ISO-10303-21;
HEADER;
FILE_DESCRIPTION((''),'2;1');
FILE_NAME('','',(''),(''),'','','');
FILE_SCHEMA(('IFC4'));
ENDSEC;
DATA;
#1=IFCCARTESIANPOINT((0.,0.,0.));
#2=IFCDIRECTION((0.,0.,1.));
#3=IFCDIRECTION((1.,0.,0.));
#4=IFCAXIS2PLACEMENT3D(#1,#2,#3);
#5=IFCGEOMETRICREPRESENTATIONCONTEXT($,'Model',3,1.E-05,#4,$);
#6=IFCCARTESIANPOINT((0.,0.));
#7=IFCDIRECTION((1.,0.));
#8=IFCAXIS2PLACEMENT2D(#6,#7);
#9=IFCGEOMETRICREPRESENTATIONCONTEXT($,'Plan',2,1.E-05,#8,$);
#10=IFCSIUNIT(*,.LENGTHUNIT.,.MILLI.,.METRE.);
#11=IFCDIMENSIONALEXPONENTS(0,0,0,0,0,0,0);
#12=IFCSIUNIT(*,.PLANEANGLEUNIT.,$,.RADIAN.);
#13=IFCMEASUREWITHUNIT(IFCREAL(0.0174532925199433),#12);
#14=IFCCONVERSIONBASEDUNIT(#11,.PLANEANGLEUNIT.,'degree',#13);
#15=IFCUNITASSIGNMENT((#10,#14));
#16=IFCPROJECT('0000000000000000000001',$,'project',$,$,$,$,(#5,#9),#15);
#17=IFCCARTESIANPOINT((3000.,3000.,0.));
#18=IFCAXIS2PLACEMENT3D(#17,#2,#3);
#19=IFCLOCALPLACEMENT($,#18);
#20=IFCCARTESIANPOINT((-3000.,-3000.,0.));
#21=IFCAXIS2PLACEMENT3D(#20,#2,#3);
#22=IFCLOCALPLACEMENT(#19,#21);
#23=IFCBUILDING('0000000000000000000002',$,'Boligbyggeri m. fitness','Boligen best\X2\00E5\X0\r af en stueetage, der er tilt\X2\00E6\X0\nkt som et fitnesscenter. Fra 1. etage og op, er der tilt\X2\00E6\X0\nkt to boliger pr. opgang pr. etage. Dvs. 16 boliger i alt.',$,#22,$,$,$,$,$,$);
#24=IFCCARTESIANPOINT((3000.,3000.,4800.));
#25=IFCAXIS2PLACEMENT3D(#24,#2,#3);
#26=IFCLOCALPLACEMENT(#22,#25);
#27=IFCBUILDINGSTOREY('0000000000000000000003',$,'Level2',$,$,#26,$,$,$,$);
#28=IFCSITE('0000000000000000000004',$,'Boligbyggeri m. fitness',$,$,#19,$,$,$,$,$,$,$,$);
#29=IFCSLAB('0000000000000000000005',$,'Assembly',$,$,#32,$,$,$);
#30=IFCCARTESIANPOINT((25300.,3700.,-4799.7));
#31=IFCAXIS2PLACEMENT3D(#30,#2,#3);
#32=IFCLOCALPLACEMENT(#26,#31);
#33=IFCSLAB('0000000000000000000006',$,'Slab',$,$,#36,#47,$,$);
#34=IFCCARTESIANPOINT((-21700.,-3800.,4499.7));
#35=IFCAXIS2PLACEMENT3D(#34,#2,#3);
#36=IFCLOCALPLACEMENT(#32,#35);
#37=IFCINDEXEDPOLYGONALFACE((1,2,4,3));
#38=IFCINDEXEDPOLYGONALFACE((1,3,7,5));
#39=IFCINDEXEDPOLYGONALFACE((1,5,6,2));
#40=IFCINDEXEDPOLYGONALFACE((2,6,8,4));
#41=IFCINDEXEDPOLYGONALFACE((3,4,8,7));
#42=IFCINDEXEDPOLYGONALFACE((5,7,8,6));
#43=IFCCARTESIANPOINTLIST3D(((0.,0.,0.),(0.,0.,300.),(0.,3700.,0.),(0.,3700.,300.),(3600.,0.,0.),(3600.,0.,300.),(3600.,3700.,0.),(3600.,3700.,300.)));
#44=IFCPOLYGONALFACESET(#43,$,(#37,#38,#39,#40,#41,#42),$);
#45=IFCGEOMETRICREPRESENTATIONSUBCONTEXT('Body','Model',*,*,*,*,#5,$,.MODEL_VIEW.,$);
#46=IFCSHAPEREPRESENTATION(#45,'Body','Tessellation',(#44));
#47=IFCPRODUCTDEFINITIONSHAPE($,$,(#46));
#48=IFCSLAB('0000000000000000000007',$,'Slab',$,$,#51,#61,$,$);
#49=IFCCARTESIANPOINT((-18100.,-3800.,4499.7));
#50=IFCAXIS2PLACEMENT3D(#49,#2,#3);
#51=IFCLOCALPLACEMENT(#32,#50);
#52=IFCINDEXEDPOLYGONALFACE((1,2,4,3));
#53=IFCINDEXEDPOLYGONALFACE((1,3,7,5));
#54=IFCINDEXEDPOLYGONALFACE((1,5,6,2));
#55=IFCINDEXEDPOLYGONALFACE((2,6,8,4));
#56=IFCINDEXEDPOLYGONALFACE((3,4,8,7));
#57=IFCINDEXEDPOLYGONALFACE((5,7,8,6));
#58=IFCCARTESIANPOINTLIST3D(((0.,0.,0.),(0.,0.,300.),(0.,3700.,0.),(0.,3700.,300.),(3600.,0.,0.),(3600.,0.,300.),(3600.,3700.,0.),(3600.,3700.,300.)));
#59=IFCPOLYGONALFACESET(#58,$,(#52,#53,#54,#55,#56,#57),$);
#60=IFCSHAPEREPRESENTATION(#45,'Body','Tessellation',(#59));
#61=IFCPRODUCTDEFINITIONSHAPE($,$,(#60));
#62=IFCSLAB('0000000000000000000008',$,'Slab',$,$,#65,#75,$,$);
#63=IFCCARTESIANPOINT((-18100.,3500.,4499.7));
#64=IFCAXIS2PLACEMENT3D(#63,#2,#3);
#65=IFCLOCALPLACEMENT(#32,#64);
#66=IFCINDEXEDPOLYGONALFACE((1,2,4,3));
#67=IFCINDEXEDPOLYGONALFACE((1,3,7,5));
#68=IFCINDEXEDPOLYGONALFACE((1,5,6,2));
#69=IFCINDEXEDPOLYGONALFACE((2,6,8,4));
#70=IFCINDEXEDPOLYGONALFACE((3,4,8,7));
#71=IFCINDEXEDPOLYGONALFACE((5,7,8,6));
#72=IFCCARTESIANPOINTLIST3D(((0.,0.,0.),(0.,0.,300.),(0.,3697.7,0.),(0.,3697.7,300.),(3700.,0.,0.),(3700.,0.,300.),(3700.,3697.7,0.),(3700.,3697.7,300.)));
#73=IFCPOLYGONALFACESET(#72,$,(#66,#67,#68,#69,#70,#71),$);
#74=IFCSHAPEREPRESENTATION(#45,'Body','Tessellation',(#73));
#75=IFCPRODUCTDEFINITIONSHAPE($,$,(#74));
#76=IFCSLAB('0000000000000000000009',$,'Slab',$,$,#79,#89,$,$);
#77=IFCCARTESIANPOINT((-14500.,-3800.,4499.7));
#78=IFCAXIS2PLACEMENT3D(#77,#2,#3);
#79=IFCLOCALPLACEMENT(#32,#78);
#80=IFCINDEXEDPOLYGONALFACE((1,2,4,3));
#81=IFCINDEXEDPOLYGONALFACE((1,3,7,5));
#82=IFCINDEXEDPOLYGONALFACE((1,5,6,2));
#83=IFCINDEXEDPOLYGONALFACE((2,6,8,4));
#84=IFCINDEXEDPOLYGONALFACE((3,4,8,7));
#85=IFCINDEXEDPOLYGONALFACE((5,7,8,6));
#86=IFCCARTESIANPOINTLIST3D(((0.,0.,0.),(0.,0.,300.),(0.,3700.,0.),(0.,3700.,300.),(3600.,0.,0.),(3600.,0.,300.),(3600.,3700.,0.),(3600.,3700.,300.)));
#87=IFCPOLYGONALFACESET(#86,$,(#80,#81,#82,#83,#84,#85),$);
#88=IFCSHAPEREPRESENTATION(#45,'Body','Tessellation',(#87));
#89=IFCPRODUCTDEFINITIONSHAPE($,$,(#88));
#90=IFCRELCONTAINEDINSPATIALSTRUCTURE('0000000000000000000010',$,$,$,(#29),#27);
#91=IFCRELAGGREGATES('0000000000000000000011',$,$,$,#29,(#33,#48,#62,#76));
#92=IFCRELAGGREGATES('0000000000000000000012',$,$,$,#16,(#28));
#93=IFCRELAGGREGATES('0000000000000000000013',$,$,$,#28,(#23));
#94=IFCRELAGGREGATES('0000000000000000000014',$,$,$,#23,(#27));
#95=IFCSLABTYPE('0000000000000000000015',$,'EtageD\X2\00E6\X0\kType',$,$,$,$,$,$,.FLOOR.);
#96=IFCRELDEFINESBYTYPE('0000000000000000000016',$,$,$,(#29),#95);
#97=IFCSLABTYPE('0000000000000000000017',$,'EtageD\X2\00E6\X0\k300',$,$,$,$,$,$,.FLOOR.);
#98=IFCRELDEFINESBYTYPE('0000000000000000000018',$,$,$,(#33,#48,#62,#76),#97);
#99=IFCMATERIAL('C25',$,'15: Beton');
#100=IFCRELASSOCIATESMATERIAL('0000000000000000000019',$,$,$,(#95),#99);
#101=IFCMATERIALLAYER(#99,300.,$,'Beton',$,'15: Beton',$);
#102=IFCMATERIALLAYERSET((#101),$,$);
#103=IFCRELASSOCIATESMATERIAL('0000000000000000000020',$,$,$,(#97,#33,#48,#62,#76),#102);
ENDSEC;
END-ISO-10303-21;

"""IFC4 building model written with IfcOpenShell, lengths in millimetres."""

from ifc_helpers import new_model, entity, si_unit, converted_unit, frame, origin_with_axes, origin_2d_with_axis, place, context, subcontext, project, spatial, line, indexed_curve, outline, extrude, material, layer, layer_set, layer_usage, type_object, element, aggregate, save


model = new_model("IFC4")

# Units and contexts
model_context = context("Model", 3, precision=1e-05, world=origin_with_axes())
plan_context = context("Plan", 2, precision=1e-05, world=origin_2d_with_axis())
body_context = subcontext(model_context, "Body", "Model", "MODEL_VIEW")
ifc_project = project(units=[si_unit("LENGTHUNIT", "METRE", prefix="MILLI"), converted_unit("PLANEANGLEUNIT", "degree", entity("IfcReal", 0.0174532925199433), si_unit("PLANEANGLEUNIT", "RADIAN"), dimensions=[0, 0, 0, 0, 0, 0, 0])], contexts=[model_context, plan_context])

# Site, building, storey
site_placement = place(None, frame((3000.0, 3000.0, 0.0), z_axis=(0.0, 0.0, 1.0), x_axis=(1.0, 0.0, 0.0)))
site = spatial("IfcSite", under=ifc_project, at=site_placement, Name="Boligbyggeri m. fitness")
building_placement = place(site_placement, frame((-3000.0, -3000.0, 0.0), z_axis=(0.0, 0.0, 1.0), x_axis=(1.0, 0.0, 0.0)))
building = spatial("IfcBuilding", under=site, at=building_placement, Name="Boligbyggeri m. fitness", Description="Boligen består af en stueetage, der er tiltænkt som et fitnesscenter. Fra 1. etage og op, er der tiltænkt to boliger pr. opgang pr. etage. Dvs. 16 boliger i alt.")
storey_placement = place(building_placement, frame((3000.0, 3000.0, 4800.0), z_axis=(0.0, 0.0, 1.0), x_axis=(1.0, 0.0, 0.0)))
storey = spatial("IfcBuildingStorey", under=building, at=storey_placement, Name="Level2")

# Shared definitions
ifc_material_1 = material(Name="C25", Category="15: Beton")

# Slabs
slab_type_1 = type_object("IfcSlabType", Name="EtageDækType", PredefinedType="FLOOR", material=ifc_material_1)
slab_1_placement = place(storey_placement, frame((25300.0, 3700.0, -4799.7), z_axis=(0.0, 0.0, 1.0), x_axis=(1.0, 0.0, 0.0)))
slab_1 = element("IfcSlab", 1, at=slab_1_placement, inside=storey, type_object=slab_type_1, Name="Assembly")
ifc_layer = layer(ifc_material_1, 300.0, Name="Beton", Category="15: Beton")
ifc_layer_set = layer_set([ifc_layer])
ifc_layer_usage_1 = layer_usage(ifc_layer_set, "AXIS3", "POSITIVE", 0.0)
slab_type_2 = type_object("IfcSlabType", Name="EtageDæk300", PredefinedType="FLOOR", material=ifc_layer_set)
slab_2_placement = place(slab_1_placement, frame((-21700.0, -3800.0, 4499.7), z_axis=(0.0, 0.0, 1.0), x_axis=(1.0, 0.0, 0.0)))
slab_2 = element("IfcSlab", 2, at=slab_2_placement, type_object=slab_type_2, material=ifc_layer_usage_1, Name="Slab", context=body_context, shape_type="SweptSolid", body=[
    extrude(outline(indexed_curve([(0.0, 0.0), (3600.0, 0.0), (3600.0, 3700.0), (0.0, 3700.0)], segments=[line(3, 2), line(2, 1), line(1, 4), line(4, 3)], self_intersect=False)), None, (0.0, 0.0, 1.0), 300.0),
])
ifc_layer_usage_2 = layer_usage(ifc_layer_set, "AXIS3", "POSITIVE", 0.0)
slab_3_placement = place(slab_1_placement, frame((-18100.0, -3800.0, 4499.7), z_axis=(0.0, 0.0, 1.0), x_axis=(1.0, 0.0, 0.0)))
slab_3 = element("IfcSlab", 3, at=slab_3_placement, type_object=slab_type_2, material=ifc_layer_usage_2, Name="Slab", context=body_context, shape_type="SweptSolid", body=[
    extrude(outline(indexed_curve([(0.0, 0.0), (3600.0, 0.0), (3600.0, 3700.0), (0.0, 3700.0)], segments=[line(3, 2), line(2, 1), line(1, 4), line(4, 3)], self_intersect=False)), None, (0.0, 0.0, 1.0), 300.0),
])
ifc_layer_usage_3 = layer_usage(ifc_layer_set, "AXIS3", "POSITIVE", 0.0)
slab_4_placement = place(slab_1_placement, frame((-18100.0, 3500.0, 4499.7), z_axis=(0.0, 0.0, 1.0), x_axis=(1.0, 0.0, 0.0)))
slab_4 = element("IfcSlab", 4, at=slab_4_placement, type_object=slab_type_2, material=ifc_layer_usage_3, Name="Slab", context=body_context, shape_type="SweptSolid", body=[
    extrude(outline(indexed_curve([(3700.0, 3697.7), (3700.0, 0.0), (0.0, 0.0), (0.0, 3697.7)], segments=[line(3, 2), line(2, 1), line(1, 4), line(4, 3)], self_intersect=False)), None, (0.0, 0.0, 1.0), 300.0),
])
ifc_layer_usage_4 = layer_usage(ifc_layer_set, "AXIS3", "POSITIVE", 0.0)
slab_5_placement = place(slab_1_placement, frame((-14500.0, -3800.0, 4499.7), z_axis=(0.0, 0.0, 1.0), x_axis=(1.0, 0.0, 0.0)))
slab_5 = element("IfcSlab", 5, at=slab_5_placement, type_object=slab_type_2, material=ifc_layer_usage_4, Name="Slab", context=body_context, shape_type="SweptSolid", body=[
    extrude(outline(indexed_curve([(0.0, 0.0), (3600.0, 0.0), (3600.0, 3700.0), (0.0, 3700.0)], segments=[line(3, 2), line(2, 1), line(1, 4), line(4, 3)], self_intersect=False)), None, (0.0, 0.0, 1.0), 300.0),
])
aggregate(slab_1, [slab_2, slab_3, slab_4, slab_5])

save(model, "model.ifc")
